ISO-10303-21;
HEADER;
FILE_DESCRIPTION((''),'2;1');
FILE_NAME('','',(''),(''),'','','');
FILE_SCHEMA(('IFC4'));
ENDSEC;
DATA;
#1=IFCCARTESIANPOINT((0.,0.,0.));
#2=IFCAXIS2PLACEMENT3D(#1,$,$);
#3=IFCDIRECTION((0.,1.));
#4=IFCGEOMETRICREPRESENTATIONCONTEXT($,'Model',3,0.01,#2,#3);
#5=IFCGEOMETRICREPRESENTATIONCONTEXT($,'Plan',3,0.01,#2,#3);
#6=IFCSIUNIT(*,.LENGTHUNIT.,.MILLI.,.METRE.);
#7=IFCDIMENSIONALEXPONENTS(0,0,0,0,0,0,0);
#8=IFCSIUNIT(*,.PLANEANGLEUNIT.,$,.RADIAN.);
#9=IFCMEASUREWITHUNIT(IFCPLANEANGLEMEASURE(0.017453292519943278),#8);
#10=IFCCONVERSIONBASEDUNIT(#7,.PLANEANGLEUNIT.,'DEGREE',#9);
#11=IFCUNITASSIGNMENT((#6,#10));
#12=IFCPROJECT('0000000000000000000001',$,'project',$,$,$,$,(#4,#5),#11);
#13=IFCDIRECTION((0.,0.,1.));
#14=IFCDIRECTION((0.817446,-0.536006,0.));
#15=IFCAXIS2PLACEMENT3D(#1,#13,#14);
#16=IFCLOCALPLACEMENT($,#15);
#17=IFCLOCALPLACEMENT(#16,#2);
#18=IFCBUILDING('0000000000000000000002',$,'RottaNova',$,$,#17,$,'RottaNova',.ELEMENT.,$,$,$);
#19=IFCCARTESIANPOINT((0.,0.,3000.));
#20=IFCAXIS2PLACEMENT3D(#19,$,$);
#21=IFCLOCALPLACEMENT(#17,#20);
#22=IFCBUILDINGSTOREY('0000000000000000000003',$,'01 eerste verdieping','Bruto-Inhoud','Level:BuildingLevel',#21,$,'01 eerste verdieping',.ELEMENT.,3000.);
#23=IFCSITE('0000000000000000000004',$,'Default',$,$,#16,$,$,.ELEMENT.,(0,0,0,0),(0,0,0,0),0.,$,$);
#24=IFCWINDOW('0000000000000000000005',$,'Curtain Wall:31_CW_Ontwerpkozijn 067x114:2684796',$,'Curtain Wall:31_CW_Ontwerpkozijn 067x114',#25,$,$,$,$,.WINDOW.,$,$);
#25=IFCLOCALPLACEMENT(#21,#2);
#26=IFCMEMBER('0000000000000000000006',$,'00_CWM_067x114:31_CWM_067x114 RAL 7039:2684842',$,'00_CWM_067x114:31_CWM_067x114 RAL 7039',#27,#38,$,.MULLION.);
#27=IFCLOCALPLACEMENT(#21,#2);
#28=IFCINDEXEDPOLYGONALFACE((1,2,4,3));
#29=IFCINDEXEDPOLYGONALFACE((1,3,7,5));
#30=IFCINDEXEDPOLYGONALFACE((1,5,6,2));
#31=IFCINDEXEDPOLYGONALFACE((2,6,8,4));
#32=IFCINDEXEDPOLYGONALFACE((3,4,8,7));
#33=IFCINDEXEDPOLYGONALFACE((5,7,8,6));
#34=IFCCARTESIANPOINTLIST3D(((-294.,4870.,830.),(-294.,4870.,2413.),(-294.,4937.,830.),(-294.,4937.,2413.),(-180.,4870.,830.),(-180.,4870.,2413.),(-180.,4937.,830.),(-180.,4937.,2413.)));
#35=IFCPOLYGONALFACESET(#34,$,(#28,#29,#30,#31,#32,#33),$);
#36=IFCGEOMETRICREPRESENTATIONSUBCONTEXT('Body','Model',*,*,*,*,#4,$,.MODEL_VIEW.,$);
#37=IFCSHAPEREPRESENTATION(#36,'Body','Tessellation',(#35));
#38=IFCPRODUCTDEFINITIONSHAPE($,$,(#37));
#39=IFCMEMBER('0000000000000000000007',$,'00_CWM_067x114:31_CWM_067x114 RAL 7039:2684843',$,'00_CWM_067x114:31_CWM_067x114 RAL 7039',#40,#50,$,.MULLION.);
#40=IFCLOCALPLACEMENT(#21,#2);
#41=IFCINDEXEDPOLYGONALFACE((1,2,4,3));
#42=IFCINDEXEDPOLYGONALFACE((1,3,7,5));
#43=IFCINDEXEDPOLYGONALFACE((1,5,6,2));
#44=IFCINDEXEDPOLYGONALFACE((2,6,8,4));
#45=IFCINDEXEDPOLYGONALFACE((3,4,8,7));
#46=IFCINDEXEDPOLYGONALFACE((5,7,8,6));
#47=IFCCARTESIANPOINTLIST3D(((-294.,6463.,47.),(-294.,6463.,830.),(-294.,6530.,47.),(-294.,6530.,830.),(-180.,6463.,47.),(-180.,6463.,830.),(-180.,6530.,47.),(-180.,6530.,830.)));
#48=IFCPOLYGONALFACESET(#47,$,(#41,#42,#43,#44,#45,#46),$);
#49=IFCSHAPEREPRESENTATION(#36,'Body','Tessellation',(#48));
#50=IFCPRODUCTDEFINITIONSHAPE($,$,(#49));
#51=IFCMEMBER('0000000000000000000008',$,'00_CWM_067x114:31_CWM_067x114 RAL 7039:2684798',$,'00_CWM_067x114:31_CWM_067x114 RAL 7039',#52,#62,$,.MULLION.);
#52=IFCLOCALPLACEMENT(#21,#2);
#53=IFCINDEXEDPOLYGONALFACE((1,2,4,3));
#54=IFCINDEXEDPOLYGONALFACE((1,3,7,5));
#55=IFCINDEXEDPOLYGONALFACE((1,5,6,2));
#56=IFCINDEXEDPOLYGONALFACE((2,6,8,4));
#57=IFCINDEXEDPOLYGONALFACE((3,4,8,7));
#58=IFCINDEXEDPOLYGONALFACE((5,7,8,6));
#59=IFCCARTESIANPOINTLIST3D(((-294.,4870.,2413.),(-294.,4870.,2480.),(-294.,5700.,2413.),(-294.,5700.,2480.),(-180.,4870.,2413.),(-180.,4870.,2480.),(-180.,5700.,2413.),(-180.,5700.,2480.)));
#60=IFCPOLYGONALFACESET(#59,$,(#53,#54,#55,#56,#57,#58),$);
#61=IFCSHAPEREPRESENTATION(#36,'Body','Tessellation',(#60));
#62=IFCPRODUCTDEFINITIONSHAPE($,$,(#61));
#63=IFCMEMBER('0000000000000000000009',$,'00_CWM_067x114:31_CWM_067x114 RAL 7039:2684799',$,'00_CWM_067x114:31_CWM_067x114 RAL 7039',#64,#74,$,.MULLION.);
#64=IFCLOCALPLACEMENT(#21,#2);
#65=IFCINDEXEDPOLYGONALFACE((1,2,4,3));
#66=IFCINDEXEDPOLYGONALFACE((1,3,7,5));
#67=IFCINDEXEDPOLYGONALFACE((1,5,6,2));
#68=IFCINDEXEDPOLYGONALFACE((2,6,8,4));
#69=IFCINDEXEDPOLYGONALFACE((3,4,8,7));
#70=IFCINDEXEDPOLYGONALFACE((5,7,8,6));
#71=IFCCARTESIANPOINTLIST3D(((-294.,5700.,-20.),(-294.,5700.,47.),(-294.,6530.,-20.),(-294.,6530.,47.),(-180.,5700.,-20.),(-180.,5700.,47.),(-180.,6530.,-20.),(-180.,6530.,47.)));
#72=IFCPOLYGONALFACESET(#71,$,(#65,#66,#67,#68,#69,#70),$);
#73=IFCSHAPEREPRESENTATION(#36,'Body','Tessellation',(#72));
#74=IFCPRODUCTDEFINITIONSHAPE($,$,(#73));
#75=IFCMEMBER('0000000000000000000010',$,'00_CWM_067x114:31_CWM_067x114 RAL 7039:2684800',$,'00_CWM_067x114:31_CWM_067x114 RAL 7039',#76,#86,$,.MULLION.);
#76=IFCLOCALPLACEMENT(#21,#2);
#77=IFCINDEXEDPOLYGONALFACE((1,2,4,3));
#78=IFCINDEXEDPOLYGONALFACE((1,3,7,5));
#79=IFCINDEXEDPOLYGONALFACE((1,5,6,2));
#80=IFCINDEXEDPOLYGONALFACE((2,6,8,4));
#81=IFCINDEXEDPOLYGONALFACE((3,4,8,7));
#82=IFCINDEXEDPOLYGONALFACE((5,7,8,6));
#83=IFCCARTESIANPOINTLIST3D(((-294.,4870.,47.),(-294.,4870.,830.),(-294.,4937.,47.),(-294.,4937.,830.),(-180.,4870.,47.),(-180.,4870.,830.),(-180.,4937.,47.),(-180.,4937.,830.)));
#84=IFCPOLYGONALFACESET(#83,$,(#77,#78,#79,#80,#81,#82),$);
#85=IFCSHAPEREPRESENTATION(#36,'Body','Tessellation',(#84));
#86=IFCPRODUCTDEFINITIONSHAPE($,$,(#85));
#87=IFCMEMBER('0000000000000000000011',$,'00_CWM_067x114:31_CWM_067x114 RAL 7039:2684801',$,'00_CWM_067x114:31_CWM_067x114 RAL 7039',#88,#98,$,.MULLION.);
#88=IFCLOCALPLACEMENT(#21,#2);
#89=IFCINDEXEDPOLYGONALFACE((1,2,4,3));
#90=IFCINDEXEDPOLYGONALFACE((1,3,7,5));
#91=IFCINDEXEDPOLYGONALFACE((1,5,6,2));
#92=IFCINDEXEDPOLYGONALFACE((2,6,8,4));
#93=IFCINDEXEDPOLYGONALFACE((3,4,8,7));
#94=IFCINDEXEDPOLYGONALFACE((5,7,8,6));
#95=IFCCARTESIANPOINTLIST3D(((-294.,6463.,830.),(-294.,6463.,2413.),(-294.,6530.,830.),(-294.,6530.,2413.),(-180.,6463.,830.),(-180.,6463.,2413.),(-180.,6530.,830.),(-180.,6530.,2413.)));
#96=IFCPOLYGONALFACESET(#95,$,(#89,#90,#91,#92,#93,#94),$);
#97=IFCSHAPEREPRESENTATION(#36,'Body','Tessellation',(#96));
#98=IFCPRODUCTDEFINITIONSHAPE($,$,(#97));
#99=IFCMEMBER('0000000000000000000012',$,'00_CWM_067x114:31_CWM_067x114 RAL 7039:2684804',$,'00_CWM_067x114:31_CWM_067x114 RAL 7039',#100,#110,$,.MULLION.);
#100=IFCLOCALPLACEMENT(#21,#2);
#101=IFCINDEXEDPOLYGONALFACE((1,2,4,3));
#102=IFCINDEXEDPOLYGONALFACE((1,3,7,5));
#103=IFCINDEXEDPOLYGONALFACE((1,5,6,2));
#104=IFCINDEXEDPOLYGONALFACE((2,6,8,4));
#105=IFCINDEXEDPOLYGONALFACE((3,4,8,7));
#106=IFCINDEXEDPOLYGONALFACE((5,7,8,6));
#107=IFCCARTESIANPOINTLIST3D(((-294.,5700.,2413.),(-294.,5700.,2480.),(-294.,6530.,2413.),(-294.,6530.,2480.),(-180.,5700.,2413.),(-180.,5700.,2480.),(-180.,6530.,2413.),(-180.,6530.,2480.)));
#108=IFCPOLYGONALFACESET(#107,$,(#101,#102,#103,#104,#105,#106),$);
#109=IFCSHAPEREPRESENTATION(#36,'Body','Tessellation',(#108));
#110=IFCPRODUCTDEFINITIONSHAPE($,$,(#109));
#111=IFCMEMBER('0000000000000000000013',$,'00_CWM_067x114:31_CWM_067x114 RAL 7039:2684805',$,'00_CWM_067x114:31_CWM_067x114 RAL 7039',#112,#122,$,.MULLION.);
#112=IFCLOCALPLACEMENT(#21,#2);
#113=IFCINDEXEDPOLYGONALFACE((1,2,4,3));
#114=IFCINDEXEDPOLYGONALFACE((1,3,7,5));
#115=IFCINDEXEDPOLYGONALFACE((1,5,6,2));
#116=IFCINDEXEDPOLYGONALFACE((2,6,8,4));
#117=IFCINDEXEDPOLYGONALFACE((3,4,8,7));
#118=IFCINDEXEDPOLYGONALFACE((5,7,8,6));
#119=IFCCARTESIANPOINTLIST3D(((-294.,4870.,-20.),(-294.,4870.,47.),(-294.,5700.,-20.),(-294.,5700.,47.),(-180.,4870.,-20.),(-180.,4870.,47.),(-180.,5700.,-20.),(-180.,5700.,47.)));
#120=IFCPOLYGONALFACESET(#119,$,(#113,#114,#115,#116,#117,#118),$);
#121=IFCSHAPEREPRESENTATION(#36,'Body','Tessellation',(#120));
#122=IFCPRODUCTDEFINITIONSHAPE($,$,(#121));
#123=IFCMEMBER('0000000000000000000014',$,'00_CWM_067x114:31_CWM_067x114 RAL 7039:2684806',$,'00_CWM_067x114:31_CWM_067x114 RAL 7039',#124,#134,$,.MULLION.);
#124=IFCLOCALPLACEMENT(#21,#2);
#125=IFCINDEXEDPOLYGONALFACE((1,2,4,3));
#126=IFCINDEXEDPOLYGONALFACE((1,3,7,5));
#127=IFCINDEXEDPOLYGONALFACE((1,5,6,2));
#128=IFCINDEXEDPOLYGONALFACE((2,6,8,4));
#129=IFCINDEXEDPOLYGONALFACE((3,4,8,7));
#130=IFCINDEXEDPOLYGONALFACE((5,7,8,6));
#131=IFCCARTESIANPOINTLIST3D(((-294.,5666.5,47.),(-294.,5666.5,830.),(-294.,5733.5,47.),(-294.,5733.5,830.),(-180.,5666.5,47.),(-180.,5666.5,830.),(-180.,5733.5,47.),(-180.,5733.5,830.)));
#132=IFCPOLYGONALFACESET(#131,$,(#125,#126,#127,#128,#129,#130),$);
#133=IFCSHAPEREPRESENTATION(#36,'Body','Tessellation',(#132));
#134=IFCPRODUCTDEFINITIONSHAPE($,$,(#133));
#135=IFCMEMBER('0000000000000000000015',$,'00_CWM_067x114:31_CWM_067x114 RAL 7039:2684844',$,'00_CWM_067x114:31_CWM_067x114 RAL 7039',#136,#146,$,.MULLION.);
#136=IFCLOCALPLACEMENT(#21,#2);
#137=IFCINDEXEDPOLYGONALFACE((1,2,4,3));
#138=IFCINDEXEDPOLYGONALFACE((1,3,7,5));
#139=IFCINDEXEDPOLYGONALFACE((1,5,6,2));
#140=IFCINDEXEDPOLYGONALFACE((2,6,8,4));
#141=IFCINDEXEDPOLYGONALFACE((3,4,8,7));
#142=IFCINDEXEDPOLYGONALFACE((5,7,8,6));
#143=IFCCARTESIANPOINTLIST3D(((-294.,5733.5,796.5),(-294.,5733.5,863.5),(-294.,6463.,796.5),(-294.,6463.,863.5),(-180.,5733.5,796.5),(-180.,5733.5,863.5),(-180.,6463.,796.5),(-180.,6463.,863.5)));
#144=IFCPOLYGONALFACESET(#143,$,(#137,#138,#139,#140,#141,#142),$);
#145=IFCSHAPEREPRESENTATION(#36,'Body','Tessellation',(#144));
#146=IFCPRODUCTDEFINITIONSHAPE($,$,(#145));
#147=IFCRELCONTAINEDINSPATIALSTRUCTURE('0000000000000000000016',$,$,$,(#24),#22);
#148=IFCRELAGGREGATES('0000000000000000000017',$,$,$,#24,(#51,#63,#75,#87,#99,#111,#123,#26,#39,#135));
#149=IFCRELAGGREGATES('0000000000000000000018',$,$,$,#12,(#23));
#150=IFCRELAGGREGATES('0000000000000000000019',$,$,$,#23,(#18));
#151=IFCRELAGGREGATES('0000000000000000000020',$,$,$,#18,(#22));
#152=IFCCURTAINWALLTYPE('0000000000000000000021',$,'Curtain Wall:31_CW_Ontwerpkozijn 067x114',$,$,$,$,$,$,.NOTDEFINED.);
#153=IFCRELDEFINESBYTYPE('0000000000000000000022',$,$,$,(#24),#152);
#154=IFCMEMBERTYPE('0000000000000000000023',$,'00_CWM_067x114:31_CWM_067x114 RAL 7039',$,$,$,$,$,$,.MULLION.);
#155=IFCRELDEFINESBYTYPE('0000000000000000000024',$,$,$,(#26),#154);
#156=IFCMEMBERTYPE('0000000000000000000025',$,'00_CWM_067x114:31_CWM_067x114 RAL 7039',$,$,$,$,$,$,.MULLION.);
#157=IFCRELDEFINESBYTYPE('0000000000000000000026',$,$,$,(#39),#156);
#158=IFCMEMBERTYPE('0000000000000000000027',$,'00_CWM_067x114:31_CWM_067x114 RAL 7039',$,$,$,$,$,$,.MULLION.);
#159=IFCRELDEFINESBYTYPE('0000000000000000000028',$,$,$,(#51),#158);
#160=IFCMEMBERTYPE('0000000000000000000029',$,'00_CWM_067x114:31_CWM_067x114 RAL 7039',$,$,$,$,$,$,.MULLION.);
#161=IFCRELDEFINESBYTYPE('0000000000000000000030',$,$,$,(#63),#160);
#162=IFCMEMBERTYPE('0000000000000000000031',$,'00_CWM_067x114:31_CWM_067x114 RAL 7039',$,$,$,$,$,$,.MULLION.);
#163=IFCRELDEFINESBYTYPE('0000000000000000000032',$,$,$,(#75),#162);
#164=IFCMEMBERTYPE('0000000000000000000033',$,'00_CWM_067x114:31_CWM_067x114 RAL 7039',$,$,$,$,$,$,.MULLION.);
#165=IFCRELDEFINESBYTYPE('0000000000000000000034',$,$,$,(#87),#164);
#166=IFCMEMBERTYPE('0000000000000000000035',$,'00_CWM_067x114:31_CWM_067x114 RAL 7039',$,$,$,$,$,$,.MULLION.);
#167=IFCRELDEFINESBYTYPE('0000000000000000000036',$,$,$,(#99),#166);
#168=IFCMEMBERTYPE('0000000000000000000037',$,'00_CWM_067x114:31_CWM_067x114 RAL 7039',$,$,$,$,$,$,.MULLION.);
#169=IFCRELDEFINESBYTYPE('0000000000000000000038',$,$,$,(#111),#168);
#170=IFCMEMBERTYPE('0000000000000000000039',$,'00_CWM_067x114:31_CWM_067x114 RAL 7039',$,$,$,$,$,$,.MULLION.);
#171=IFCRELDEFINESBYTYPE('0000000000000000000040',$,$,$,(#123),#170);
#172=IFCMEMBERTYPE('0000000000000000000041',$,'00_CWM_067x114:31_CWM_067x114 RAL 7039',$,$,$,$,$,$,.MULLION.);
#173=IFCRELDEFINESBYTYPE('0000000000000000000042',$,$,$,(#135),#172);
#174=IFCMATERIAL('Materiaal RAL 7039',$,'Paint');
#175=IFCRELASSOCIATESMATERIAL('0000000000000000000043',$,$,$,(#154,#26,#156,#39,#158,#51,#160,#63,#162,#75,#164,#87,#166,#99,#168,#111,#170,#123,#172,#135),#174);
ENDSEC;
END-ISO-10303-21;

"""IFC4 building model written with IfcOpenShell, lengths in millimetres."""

from ifc_helpers import new_model, entity, si_unit, converted_unit, direction, frame, origin, place, context, subcontext, project, spatial, indexed_curve, outline, extrude, source, transform, mapped, material, type_object, type_shapes, element, aggregate, save


model = new_model("IFC4")

# Units and contexts
model_context = context("Model", 3, precision=0.01, world=origin(), true_north=direction((0.0, 1.0)))
plan_context = context("Plan", 3, precision=0.01, world=origin(), true_north=direction((0.0, 1.0)))
body_context = subcontext(model_context, "Body", "Model", "MODEL_VIEW")
ifc_project = project(units=[si_unit("LENGTHUNIT", "METRE", prefix="MILLI"), converted_unit("PLANEANGLEUNIT", "DEGREE", entity("IfcPlaneAngleMeasure", 0.017453292519943278), si_unit("PLANEANGLEUNIT", "RADIAN"), dimensions=[0, 0, 0, 0, 0, 0, 0])], contexts=[model_context, plan_context])

# Site, building, storey
site_placement = place(None, frame((0.0, 0.0, 0.0), z_axis=(0.0, 0.0, 1.0), x_axis=(0.817446, -0.536006, 0.0)))
site = spatial("IfcSite", under=ifc_project, at=site_placement, Name="Default", CompositionType="ELEMENT", RefLatitude=(0, 0, 0, 0), RefLongitude=(0, 0, 0, 0), RefElevation=0.0)
building_placement = place(site_placement, origin())
building = spatial("IfcBuilding", under=site, at=building_placement, Name="RottaNova", LongName="RottaNova", CompositionType="ELEMENT")
storey_placement = place(building_placement, frame((0.0, 0.0, 3000.0)))
storey = spatial("IfcBuildingStorey", under=building, at=storey_placement, Name="01 eerste verdieping", Description="Bruto-Inhoud", ObjectType="Level:BuildingLevel", LongName="01 eerste verdieping", CompositionType="ELEMENT", Elevation=3000.0)

# Window, members
curtain_wall_type = type_object("IfcCurtainWallType", Name="Curtain Wall:31_CW_Ontwerpkozijn 067x114", PredefinedType="NOTDEFINED")
window_placement = place(storey_placement, frame((0.0, 0.0, -3000.0)))
window = element("IfcWindow", 1, at=window_placement, inside=storey, type_object=curtain_wall_type, Name="Curtain Wall:31_CW_Ontwerpkozijn 067x114:2684796", ObjectType="Curtain Wall:31_CW_Ontwerpkozijn 067x114", PredefinedType="WINDOW")
ifc_material_1 = material(Name="Materiaal RAL 7039", Category="Paint")
member_type_1 = type_object("IfcMemberType", Name="00_CWM_067x114:31_CWM_067x114 RAL 7039", PredefinedType="MULLION", material=ifc_material_1)
shared_shape_1 = source(origin(), body_context, "Body", "SweptSolid", [
    extrude(outline(indexed_curve([(-33.5, -57.0), (33.5, -57.0), (33.5, 57.0), (-33.5, 57.0), (-33.5, -57.0)], self_intersect=False)), frame((-33.5, 57.0, -1583.0), z_axis=(0.0, 0.0, 1.0), x_axis=(-1.0, 0.0, 0.0)), (0.0, 0.0, 1.0), 1583.0),
])
type_shapes(member_type_1, [shared_shape_1])
member_1_placement = place(window_placement, frame((-180.0, 4870.0, 3830.0), z_axis=(0.0, 0.0, -1.0), x_axis=(0.0, -1.0, 0.0)))
member_1 = element("IfcMember", 2, at=member_1_placement, type_object=member_type_1, material=ifc_material_1, Name="00_CWM_067x114:31_CWM_067x114 RAL 7039:2684842", ObjectType="00_CWM_067x114:31_CWM_067x114 RAL 7039", PredefinedType="MULLION", context=body_context, shape_type="MappedRepresentation", body=[
    mapped(shared_shape_1, transform((0.0, 0.0, 0.0), scale=1.0)),
])
member_type_2 = type_object("IfcMemberType", Name="00_CWM_067x114:31_CWM_067x114 RAL 7039", PredefinedType="MULLION", material=ifc_material_1)
shared_shape_2 = source(origin(), body_context, "Body", "SweptSolid", [
    extrude(outline(indexed_curve([(-33.5, -57.0), (33.5, -57.0), (33.5, 57.0), (-33.5, 57.0), (-33.5, -57.0)], self_intersect=False)), frame((-33.5, 57.0, -783.0), z_axis=(0.0, 0.0, 1.0), x_axis=(-1.0, 0.0, 0.0)), (0.0, 0.0, 1.0), 783.0),
])
type_shapes(member_type_2, [shared_shape_2])
member_2_placement = place(window_placement, frame((-180.0, 6530.0, 3830.0), z_axis=(0.0, 0.0, 1.0), x_axis=(0.0, 1.0, 0.0)))
member_2 = element("IfcMember", 3, at=member_2_placement, type_object=member_type_2, material=ifc_material_1, Name="00_CWM_067x114:31_CWM_067x114 RAL 7039:2684843", ObjectType="00_CWM_067x114:31_CWM_067x114 RAL 7039", PredefinedType="MULLION", context=body_context, shape_type="MappedRepresentation", body=[
    mapped(shared_shape_2, transform((0.0, 0.0, 0.0), scale=1.0)),
])
member_type_3 = type_object("IfcMemberType", Name="00_CWM_067x114:31_CWM_067x114 RAL 7039", PredefinedType="MULLION", material=ifc_material_1)
shared_shape_3 = source(origin(), body_context, "Body", "SweptSolid", [
    extrude(outline(indexed_curve([(-33.5, -57.0), (33.5, -57.0), (33.5, 57.0), (-33.5, 57.0), (-33.5, -57.0)], self_intersect=False)), frame((-33.5, 57.0, -830.0), z_axis=(0.0, 0.0, 1.0), x_axis=(-1.0, 0.0, 0.0)), (0.0, 0.0, 1.0), 830.0),
])
type_shapes(member_type_3, [shared_shape_3])
member_3_placement = place(window_placement, frame((-180.0, 4870.0, 5480.0), z_axis=(0.0, -1.0, 0.0), x_axis=(0.0, 0.0, 1.0)))
member_3 = element("IfcMember", 4, at=member_3_placement, type_object=member_type_3, material=ifc_material_1, Name="00_CWM_067x114:31_CWM_067x114 RAL 7039:2684798", ObjectType="00_CWM_067x114:31_CWM_067x114 RAL 7039", PredefinedType="MULLION", context=body_context, shape_type="MappedRepresentation", body=[
    mapped(shared_shape_3, transform((0.0, 0.0, 0.0), scale=1.0)),
])
member_type_4 = type_object("IfcMemberType", Name="00_CWM_067x114:31_CWM_067x114 RAL 7039", PredefinedType="MULLION", material=ifc_material_1)
shared_shape_4 = source(origin(), body_context, "Body", "SweptSolid", [
    extrude(outline(indexed_curve([(-33.5, -57.0), (33.5, -57.0), (33.5, 57.0), (-33.5, 57.0), (-33.5, -57.0)], self_intersect=False)), frame((-33.5, 57.0, -830.0), z_axis=(0.0, 0.0, 1.0), x_axis=(-1.0, 0.0, 0.0)), (0.0, 0.0, 1.0), 830.0),
])
type_shapes(member_type_4, [shared_shape_4])
member_4_placement = place(window_placement, frame((-180.0, 6530.0, 2980.0), z_axis=(0.0, 1.0, 0.0), x_axis=(0.0, 0.0, -1.0)))
member_4 = element("IfcMember", 5, at=member_4_placement, type_object=member_type_4, material=ifc_material_1, Name="00_CWM_067x114:31_CWM_067x114 RAL 7039:2684799", ObjectType="00_CWM_067x114:31_CWM_067x114 RAL 7039", PredefinedType="MULLION", context=body_context, shape_type="MappedRepresentation", body=[
    mapped(shared_shape_4, transform((0.0, 0.0, 0.0), scale=1.0)),
])
member_type_5 = type_object("IfcMemberType", Name="00_CWM_067x114:31_CWM_067x114 RAL 7039", PredefinedType="MULLION", material=ifc_material_1)
shared_shape_5 = source(origin(), body_context, "Body", "SweptSolid", [
    extrude(outline(indexed_curve([(-33.5, -57.0), (33.5, -57.0), (33.5, 57.0), (-33.5, 57.0), (-33.5, -57.0)], self_intersect=False)), frame((-33.5, 57.0, -783.0), z_axis=(0.0, 0.0, 1.0), x_axis=(-1.0, 0.0, 0.0)), (0.0, 0.0, 1.0), 783.0),
])
type_shapes(member_type_5, [shared_shape_5])
member_5_placement = place(window_placement, frame((-180.0, 4870.0, 3047.0), z_axis=(0.0, 0.0, -1.0), x_axis=(0.0, -1.0, 0.0)))
member_5 = element("IfcMember", 6, at=member_5_placement, type_object=member_type_5, material=ifc_material_1, Name="00_CWM_067x114:31_CWM_067x114 RAL 7039:2684800", ObjectType="00_CWM_067x114:31_CWM_067x114 RAL 7039", PredefinedType="MULLION", context=body_context, shape_type="MappedRepresentation", body=[
    mapped(shared_shape_5, transform((0.0, 0.0, 0.0), scale=1.0)),
])
member_type_6 = type_object("IfcMemberType", Name="00_CWM_067x114:31_CWM_067x114 RAL 7039", PredefinedType="MULLION", material=ifc_material_1)
shared_shape_6 = source(origin(), body_context, "Body", "SweptSolid", [
    extrude(outline(indexed_curve([(-33.5, -57.0), (33.5, -57.0), (33.5, 57.0), (-33.5, 57.0), (-33.5, -57.0)], self_intersect=False)), frame((-33.5, 57.0, -1583.0), z_axis=(0.0, 0.0, 1.0), x_axis=(-1.0, 0.0, 0.0)), (0.0, 0.0, 1.0), 1583.0),
])
type_shapes(member_type_6, [shared_shape_6])
member_6_placement = place(window_placement, frame((-180.0, 6530.0, 5413.0), z_axis=(0.0, 0.0, 1.0), x_axis=(0.0, 1.0, 0.0)))
member_6 = element("IfcMember", 7, at=member_6_placement, type_object=member_type_6, material=ifc_material_1, Name="00_CWM_067x114:31_CWM_067x114 RAL 7039:2684801", ObjectType="00_CWM_067x114:31_CWM_067x114 RAL 7039", PredefinedType="MULLION", context=body_context, shape_type="MappedRepresentation", body=[
    mapped(shared_shape_6, transform((0.0, 0.0, 0.0), scale=1.0)),
])
member_type_7 = type_object("IfcMemberType", Name="00_CWM_067x114:31_CWM_067x114 RAL 7039", PredefinedType="MULLION", material=ifc_material_1)
shared_shape_7 = source(origin(), body_context, "Body", "SweptSolid", [
    extrude(outline(indexed_curve([(-33.5, -57.0), (33.5, -57.0), (33.5, 57.0), (-33.5, 57.0), (-33.5, -57.0)], self_intersect=False)), frame((-33.5, 57.0, -830.0), z_axis=(0.0, 0.0, 1.0), x_axis=(-1.0, 0.0, 0.0)), (0.0, 0.0, 1.0), 830.0),
])
type_shapes(member_type_7, [shared_shape_7])
member_7_placement = place(window_placement, frame((-180.0, 5700.0, 5480.0), z_axis=(0.0, -1.0, 0.0), x_axis=(0.0, 0.0, 1.0)))
member_7 = element("IfcMember", 8, at=member_7_placement, type_object=member_type_7, material=ifc_material_1, Name="00_CWM_067x114:31_CWM_067x114 RAL 7039:2684804", ObjectType="00_CWM_067x114:31_CWM_067x114 RAL 7039", PredefinedType="MULLION", context=body_context, shape_type="MappedRepresentation", body=[
    mapped(shared_shape_7, transform((0.0, 0.0, 0.0), scale=1.0)),
])
member_type_8 = type_object("IfcMemberType", Name="00_CWM_067x114:31_CWM_067x114 RAL 7039", PredefinedType="MULLION", material=ifc_material_1)
shared_shape_8 = source(origin(), body_context, "Body", "SweptSolid", [
    extrude(outline(indexed_curve([(-33.5, -57.0), (33.5, -57.0), (33.5, 57.0), (-33.5, 57.0), (-33.5, -57.0)], self_intersect=False)), frame((-33.5, 57.0, -830.0), z_axis=(0.0, 0.0, 1.0), x_axis=(-1.0, 0.0, 0.0)), (0.0, 0.0, 1.0), 830.0),
])
type_shapes(member_type_8, [shared_shape_8])
member_8_placement = place(window_placement, frame((-180.0, 5700.0, 2980.0), z_axis=(0.0, 1.0, 0.0), x_axis=(0.0, 0.0, -1.0)))
member_8 = element("IfcMember", 9, at=member_8_placement, type_object=member_type_8, material=ifc_material_1, Name="00_CWM_067x114:31_CWM_067x114 RAL 7039:2684805", ObjectType="00_CWM_067x114:31_CWM_067x114 RAL 7039", PredefinedType="MULLION", context=body_context, shape_type="MappedRepresentation", body=[
    mapped(shared_shape_8, transform((0.0, 0.0, 0.0), scale=1.0)),
])
member_type_9 = type_object("IfcMemberType", Name="00_CWM_067x114:31_CWM_067x114 RAL 7039", PredefinedType="MULLION", material=ifc_material_1)
shared_shape_9 = source(origin(), body_context, "Body", "SweptSolid", [
    extrude(outline(indexed_curve([(-33.5, -57.0), (33.5, -57.0), (33.5, 57.0), (-33.5, 57.0), (-33.5, -57.0)], self_intersect=False)), frame((0.0, 57.0, -783.0), z_axis=(0.0, 0.0, 1.0), x_axis=(-1.0, 0.0, 0.0)), (0.0, 0.0, 1.0), 783.0),
])
type_shapes(member_type_9, [shared_shape_9])
member_9_placement = place(window_placement, frame((-180.0, 5700.0, 3047.0), z_axis=(0.0, 0.0, -1.0), x_axis=(0.0, -1.0, 0.0)))
member_9 = element("IfcMember", 10, at=member_9_placement, type_object=member_type_9, material=ifc_material_1, Name="00_CWM_067x114:31_CWM_067x114 RAL 7039:2684806", ObjectType="00_CWM_067x114:31_CWM_067x114 RAL 7039", PredefinedType="MULLION", context=body_context, shape_type="MappedRepresentation", body=[
    mapped(shared_shape_9, transform((0.0, 0.0, 0.0), scale=1.0)),
])
member_type_10 = type_object("IfcMemberType", Name="00_CWM_067x114:31_CWM_067x114 RAL 7039", PredefinedType="MULLION", material=ifc_material_1)
shared_shape_10 = source(origin(), body_context, "Body", "SweptSolid", [
    extrude(outline(indexed_curve([(-33.5, -57.0), (33.5, -57.0), (33.5, 57.0), (-33.5, 57.0), (-33.5, -57.0)], self_intersect=False)), frame((0.0, 57.0, -729.5), z_axis=(0.0, 0.0, 1.0), x_axis=(-1.0, 0.0, 0.0)), (0.0, 0.0, 1.0), 729.5),
])
type_shapes(member_type_10, [shared_shape_10])
member_10_placement = place(window_placement, frame((-180.0, 5733.5, 3830.0), z_axis=(0.0, -1.0, 0.0), x_axis=(0.0, 0.0, 1.0)))
member_10 = element("IfcMember", 11, at=member_10_placement, type_object=member_type_10, material=ifc_material_1, Name="00_CWM_067x114:31_CWM_067x114 RAL 7039:2684844", ObjectType="00_CWM_067x114:31_CWM_067x114 RAL 7039", PredefinedType="MULLION", context=body_context, shape_type="MappedRepresentation", body=[
    mapped(shared_shape_10, transform((0.0, 0.0, 0.0), scale=1.0)),
])
aggregate(window, [member_3, member_4, member_5, member_6, member_7, member_8, member_9, member_1, member_2, member_10])

save(model, "model.ifc")
